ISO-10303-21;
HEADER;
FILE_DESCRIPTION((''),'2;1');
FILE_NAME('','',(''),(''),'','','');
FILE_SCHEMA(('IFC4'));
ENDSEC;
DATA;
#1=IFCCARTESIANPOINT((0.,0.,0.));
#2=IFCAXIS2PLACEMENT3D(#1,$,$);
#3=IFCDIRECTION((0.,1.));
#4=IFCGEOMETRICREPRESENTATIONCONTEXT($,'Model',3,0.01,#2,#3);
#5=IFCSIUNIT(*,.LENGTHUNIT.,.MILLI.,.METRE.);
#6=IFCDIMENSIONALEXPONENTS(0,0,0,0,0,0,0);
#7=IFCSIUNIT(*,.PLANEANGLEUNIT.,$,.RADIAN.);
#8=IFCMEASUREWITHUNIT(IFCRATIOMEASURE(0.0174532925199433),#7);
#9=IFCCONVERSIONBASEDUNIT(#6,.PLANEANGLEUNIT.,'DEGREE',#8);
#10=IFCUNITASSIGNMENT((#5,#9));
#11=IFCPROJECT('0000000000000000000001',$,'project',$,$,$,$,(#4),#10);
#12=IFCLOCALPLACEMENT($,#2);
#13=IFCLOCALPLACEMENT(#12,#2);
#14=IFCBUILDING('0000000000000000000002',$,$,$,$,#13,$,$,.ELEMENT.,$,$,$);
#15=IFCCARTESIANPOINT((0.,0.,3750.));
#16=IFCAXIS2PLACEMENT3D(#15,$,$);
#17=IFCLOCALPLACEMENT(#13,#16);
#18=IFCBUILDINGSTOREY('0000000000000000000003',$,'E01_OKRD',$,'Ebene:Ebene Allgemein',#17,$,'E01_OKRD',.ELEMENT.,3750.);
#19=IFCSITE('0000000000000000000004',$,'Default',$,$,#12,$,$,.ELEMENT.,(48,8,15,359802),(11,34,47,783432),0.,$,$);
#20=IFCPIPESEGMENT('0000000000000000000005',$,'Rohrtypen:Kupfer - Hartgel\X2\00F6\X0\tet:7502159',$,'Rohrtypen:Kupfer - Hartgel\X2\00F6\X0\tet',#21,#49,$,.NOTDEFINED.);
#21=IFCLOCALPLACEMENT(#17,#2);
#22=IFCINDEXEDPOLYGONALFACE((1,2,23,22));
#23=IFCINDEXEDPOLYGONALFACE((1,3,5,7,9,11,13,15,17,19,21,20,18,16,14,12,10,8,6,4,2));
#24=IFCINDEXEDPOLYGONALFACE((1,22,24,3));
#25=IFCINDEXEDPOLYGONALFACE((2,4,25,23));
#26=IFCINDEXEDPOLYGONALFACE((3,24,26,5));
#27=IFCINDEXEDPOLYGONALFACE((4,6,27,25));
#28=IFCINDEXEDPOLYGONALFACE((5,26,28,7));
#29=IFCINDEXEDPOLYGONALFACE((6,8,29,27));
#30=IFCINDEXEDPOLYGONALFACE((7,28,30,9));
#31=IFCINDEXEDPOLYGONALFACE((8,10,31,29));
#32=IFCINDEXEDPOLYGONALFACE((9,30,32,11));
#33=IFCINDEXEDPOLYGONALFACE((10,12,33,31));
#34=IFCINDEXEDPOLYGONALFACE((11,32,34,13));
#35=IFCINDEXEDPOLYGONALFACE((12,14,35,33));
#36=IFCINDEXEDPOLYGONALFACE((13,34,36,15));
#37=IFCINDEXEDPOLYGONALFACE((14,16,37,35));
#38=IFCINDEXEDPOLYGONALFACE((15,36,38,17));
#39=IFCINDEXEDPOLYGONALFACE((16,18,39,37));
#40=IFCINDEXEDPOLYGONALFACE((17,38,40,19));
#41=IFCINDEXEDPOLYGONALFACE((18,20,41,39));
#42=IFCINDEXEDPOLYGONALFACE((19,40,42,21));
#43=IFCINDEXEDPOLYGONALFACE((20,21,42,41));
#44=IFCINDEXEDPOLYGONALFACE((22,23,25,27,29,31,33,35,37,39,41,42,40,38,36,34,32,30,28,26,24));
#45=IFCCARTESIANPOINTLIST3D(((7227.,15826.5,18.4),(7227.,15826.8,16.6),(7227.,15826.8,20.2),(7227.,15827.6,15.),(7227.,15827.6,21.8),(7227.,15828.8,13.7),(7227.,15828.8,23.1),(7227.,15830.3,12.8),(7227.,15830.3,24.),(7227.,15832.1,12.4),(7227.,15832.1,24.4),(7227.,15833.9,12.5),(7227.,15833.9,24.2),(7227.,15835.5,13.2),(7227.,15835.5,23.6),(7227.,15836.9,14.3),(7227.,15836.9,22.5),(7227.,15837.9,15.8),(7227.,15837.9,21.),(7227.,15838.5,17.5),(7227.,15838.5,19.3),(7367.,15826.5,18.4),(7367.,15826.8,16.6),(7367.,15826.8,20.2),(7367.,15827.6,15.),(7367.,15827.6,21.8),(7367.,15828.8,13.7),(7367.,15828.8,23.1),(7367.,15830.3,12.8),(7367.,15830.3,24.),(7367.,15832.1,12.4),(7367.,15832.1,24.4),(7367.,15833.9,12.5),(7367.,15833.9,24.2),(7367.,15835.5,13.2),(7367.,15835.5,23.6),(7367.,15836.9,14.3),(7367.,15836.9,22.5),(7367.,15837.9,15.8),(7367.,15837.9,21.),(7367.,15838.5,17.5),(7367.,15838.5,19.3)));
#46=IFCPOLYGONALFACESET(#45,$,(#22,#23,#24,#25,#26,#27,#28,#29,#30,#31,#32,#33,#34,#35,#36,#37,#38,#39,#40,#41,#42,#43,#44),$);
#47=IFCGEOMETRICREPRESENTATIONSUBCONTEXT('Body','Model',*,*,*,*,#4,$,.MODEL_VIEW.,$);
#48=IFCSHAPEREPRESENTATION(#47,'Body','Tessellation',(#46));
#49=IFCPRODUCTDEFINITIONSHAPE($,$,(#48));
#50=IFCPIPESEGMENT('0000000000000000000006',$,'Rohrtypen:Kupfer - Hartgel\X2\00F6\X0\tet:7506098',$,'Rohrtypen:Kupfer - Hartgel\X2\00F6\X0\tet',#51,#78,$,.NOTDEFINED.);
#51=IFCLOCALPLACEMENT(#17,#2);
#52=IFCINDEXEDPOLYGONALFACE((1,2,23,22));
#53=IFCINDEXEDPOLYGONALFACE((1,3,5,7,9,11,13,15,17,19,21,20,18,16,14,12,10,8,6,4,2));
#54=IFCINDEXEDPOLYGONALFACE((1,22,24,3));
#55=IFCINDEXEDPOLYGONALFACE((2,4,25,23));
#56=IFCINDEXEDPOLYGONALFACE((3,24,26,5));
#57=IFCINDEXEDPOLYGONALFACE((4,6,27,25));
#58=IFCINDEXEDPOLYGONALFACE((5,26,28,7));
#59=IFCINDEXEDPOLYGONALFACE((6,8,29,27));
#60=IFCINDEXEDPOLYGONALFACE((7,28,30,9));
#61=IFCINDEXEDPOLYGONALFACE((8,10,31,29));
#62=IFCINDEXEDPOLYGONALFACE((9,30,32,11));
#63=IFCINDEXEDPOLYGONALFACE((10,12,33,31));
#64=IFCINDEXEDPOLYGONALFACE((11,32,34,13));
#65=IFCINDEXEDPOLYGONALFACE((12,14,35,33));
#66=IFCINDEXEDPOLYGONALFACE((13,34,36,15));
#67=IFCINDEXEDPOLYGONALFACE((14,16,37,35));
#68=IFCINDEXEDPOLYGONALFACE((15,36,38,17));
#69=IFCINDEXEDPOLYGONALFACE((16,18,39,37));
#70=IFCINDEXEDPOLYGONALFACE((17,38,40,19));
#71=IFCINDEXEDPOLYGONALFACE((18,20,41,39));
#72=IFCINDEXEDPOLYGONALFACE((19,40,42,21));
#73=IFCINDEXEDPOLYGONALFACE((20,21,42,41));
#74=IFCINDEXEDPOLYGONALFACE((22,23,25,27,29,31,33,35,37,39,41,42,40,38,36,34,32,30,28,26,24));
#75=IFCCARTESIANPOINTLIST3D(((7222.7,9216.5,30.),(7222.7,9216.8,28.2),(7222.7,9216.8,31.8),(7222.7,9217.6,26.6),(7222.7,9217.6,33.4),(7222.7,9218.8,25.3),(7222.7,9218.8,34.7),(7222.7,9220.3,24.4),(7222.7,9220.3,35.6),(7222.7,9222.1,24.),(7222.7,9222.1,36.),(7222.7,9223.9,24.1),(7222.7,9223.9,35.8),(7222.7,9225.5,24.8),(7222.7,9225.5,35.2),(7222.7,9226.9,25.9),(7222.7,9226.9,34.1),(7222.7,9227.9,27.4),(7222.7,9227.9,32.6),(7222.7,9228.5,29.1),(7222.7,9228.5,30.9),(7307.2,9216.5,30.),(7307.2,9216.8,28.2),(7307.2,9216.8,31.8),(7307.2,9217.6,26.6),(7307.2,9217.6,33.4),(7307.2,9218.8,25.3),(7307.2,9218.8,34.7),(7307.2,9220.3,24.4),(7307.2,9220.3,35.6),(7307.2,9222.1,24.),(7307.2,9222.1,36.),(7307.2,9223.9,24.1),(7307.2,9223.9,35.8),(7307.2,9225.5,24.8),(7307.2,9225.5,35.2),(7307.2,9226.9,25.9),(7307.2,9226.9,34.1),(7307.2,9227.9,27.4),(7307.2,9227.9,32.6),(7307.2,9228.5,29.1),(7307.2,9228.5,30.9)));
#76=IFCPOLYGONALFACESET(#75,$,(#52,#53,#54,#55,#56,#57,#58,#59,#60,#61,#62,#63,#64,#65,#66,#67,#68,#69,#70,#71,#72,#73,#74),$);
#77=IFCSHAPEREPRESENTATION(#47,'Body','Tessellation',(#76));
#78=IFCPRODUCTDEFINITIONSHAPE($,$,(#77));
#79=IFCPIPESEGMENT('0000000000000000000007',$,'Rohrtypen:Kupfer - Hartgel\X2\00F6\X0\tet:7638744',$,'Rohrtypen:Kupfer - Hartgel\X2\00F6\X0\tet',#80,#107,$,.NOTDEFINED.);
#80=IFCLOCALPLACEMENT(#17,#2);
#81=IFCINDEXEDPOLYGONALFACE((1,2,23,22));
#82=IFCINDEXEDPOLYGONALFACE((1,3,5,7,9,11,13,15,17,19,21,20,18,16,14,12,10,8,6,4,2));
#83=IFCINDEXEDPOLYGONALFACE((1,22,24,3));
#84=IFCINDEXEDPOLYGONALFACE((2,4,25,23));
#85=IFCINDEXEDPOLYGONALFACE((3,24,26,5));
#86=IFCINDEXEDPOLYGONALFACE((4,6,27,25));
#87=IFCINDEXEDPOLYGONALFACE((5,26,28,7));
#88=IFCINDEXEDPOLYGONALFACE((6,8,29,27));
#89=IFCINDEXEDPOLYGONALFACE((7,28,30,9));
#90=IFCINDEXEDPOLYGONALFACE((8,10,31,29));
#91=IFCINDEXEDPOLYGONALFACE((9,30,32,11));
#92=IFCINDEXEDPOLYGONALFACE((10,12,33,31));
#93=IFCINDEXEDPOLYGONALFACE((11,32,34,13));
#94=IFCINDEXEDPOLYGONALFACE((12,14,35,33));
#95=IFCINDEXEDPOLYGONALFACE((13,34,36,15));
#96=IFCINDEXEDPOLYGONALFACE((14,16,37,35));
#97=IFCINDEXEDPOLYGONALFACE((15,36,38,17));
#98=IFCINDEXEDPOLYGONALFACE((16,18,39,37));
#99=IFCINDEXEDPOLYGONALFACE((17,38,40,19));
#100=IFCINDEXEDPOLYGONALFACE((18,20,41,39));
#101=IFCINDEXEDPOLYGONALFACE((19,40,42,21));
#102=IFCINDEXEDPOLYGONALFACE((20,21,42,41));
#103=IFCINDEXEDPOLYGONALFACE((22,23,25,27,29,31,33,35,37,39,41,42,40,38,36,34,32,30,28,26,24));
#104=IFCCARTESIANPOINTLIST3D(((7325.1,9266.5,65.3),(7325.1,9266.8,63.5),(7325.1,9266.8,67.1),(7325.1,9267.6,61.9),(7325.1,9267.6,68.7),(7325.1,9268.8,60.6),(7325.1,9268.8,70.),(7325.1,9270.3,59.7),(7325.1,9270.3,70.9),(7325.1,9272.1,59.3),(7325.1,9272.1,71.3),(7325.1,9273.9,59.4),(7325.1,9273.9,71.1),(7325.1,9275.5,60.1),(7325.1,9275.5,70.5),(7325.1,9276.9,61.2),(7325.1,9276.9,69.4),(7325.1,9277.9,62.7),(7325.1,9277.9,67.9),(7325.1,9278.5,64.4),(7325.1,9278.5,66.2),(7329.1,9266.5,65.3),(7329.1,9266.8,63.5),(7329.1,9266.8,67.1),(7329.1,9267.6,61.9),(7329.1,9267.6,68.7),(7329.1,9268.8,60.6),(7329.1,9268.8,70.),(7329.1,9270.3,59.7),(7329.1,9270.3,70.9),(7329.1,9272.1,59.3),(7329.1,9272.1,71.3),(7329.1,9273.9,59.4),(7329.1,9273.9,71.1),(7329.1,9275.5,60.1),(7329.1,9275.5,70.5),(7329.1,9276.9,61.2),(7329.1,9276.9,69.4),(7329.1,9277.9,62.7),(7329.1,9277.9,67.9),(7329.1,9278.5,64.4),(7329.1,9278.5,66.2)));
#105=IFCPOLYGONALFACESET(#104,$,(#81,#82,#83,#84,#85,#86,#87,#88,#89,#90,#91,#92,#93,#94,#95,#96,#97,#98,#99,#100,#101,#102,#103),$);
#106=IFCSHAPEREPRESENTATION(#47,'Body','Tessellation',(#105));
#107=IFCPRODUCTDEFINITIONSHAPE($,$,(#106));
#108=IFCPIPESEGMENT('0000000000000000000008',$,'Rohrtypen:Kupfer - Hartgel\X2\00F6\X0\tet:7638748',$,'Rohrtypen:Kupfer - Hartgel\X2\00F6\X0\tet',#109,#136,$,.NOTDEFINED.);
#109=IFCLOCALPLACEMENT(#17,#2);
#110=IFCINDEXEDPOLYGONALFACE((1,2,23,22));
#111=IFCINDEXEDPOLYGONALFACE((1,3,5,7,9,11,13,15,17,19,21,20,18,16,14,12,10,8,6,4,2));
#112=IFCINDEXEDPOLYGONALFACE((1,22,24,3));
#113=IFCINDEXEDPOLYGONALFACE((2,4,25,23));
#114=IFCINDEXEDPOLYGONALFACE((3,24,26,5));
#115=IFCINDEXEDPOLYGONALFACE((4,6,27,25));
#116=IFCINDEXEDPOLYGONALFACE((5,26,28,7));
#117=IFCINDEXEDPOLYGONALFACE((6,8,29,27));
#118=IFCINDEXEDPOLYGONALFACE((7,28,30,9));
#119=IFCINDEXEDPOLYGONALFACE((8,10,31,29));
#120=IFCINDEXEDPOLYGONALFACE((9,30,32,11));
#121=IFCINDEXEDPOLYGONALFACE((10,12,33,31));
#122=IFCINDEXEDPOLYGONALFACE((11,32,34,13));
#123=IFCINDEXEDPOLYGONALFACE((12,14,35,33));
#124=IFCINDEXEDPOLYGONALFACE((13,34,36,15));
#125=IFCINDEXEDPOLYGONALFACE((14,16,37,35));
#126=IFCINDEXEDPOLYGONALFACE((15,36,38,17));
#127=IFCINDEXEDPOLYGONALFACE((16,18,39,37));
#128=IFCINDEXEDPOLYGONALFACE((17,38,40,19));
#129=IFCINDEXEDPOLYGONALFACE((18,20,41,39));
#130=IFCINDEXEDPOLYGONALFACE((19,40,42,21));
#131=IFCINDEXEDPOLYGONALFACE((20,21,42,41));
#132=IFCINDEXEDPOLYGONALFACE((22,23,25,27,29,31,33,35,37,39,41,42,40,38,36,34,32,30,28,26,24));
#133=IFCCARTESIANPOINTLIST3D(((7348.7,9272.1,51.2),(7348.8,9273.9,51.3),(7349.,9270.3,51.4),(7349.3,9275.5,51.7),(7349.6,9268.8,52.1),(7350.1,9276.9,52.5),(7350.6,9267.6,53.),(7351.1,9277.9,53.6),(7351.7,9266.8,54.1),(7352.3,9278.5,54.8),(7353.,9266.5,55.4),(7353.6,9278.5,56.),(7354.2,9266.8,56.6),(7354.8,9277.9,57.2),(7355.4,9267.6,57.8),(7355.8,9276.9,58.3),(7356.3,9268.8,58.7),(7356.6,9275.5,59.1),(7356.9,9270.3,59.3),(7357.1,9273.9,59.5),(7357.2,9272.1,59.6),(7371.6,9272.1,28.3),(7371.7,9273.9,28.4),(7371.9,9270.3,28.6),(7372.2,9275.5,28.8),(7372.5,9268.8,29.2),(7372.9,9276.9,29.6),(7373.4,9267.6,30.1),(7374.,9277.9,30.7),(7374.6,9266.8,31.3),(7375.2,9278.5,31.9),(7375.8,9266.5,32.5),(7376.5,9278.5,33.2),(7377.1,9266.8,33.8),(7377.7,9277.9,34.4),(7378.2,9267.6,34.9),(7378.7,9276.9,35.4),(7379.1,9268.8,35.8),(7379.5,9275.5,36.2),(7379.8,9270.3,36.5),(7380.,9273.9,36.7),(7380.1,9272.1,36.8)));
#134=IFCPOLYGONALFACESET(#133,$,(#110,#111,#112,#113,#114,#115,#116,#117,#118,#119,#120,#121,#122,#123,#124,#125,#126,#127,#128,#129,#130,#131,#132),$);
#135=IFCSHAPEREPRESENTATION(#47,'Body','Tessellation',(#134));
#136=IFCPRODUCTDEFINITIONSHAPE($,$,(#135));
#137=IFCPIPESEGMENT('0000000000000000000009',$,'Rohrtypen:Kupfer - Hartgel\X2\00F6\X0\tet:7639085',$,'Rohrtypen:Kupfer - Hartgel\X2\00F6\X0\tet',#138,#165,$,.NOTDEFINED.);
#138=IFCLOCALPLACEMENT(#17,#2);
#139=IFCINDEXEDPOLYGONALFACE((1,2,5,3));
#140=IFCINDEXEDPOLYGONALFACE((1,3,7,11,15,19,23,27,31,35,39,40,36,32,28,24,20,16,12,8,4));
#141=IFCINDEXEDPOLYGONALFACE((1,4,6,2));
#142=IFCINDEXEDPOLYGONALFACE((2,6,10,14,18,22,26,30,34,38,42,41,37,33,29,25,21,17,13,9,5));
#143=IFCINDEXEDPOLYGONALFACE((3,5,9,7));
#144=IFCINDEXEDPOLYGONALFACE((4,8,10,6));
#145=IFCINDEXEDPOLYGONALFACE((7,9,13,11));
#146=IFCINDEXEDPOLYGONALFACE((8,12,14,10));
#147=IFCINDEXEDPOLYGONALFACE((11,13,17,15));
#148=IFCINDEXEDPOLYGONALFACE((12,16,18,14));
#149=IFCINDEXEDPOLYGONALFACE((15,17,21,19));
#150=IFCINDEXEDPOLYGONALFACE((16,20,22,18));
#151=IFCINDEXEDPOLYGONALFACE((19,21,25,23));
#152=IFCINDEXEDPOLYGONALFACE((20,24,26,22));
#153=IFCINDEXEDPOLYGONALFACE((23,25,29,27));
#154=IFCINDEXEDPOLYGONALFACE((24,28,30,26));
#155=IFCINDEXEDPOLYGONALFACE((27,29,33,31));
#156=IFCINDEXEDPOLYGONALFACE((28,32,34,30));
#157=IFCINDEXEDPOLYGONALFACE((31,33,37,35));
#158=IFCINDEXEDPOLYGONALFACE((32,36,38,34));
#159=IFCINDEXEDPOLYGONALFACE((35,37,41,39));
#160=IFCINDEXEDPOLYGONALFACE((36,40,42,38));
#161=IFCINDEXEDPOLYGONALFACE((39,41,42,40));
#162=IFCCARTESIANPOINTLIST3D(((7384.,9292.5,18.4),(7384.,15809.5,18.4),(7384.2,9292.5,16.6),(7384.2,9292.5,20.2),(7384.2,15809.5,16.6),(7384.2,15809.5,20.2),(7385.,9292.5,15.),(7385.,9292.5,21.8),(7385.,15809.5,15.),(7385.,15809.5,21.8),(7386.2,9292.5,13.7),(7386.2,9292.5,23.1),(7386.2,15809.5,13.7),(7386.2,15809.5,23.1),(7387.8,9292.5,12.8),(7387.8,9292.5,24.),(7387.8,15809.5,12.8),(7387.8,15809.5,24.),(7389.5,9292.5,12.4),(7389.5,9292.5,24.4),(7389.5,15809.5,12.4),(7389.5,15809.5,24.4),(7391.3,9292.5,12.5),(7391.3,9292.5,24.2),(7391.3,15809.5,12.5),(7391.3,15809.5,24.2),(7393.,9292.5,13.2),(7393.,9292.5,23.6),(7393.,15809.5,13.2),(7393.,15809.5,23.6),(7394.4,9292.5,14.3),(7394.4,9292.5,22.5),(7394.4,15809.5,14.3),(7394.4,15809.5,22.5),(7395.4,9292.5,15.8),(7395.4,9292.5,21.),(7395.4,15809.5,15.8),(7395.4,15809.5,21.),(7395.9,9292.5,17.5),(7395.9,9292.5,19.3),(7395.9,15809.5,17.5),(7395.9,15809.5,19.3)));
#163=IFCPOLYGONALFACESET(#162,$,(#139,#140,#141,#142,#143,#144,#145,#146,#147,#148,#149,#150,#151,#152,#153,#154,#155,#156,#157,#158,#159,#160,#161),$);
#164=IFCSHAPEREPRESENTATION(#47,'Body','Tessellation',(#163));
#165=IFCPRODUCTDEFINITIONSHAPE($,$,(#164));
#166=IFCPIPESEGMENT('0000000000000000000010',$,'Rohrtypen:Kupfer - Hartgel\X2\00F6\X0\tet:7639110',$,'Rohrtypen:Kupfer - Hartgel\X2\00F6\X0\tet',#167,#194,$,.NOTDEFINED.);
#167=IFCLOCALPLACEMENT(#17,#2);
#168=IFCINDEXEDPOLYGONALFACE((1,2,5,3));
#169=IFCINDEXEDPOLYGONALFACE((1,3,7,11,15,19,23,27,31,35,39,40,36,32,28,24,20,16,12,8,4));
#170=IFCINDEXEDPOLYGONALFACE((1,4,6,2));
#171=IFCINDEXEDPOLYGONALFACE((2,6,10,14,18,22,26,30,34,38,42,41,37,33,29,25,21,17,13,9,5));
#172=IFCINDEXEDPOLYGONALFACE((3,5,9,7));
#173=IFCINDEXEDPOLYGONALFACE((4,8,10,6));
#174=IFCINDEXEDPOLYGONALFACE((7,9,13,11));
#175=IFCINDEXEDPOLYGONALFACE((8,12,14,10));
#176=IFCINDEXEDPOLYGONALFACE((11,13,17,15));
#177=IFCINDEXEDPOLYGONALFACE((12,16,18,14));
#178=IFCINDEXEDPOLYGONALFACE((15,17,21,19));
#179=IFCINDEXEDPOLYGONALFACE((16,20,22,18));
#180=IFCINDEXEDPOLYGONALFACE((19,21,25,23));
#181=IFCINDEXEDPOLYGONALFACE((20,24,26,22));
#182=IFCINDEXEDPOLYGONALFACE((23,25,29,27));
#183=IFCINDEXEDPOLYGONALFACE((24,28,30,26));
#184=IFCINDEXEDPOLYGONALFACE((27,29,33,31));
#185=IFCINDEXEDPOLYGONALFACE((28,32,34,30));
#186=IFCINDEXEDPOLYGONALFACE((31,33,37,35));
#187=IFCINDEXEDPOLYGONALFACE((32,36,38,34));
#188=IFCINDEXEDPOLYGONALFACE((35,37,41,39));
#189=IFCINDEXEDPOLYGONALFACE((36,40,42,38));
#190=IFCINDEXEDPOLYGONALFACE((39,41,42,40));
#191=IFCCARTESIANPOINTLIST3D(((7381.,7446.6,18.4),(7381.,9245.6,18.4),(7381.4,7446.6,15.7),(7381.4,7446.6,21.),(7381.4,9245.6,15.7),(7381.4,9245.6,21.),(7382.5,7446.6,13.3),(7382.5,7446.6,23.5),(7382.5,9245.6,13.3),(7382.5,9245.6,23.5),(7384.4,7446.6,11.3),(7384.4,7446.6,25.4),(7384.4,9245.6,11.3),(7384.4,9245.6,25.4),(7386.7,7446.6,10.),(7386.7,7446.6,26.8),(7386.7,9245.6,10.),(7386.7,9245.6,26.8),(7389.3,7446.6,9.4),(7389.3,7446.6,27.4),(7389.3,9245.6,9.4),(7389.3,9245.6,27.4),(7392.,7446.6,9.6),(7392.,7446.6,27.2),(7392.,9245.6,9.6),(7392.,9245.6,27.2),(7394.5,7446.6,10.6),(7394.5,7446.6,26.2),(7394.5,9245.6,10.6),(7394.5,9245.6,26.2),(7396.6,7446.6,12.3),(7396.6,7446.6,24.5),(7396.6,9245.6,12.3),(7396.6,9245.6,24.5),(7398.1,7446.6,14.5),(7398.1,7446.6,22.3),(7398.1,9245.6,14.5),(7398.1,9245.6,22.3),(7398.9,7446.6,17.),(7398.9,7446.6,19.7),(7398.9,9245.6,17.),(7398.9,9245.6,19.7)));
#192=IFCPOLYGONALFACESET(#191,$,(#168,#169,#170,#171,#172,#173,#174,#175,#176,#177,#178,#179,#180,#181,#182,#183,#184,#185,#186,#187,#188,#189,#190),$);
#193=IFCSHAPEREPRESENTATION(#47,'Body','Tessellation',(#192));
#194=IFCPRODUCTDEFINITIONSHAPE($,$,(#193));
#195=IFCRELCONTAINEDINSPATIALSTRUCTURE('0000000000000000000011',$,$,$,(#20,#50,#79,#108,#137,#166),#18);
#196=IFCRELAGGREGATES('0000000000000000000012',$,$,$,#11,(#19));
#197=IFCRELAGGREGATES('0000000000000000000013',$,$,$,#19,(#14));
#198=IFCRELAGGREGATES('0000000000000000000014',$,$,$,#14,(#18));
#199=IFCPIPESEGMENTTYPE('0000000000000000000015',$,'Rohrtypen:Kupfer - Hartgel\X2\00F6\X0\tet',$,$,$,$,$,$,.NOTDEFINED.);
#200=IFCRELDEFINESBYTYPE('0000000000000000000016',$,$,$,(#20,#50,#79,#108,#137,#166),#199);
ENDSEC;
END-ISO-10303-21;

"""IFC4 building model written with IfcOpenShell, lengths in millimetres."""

from ifc_helpers import new_model, entity, si_unit, converted_unit, direction, frame, frame_2d, origin, origin_2d_with_axis, place, context, subcontext, project, spatial, circle, extrude, type_object, element, save


model = new_model("IFC4")

# Units and contexts
model_context = context("Model", 3, precision=0.01, world=origin(), true_north=direction((0.0, 1.0)))
body_context = subcontext(model_context, "Body", "Model", "MODEL_VIEW")
ifc_project = project(units=[si_unit("LENGTHUNIT", "METRE", prefix="MILLI"), converted_unit("PLANEANGLEUNIT", "DEGREE", entity("IfcRatioMeasure", 0.0174532925199433), si_unit("PLANEANGLEUNIT", "RADIAN"), dimensions=[0, 0, 0, 0, 0, 0, 0])], contexts=[model_context])

# Site, building, storey
site_placement = place(None, origin())
site = spatial("IfcSite", under=ifc_project, at=site_placement, Name="Default", CompositionType="ELEMENT", RefLatitude=(48, 8, 15, 359802), RefLongitude=(11, 34, 47, 783432), RefElevation=0.0)
building_placement = place(site_placement, origin())
building = spatial("IfcBuilding", under=site, at=building_placement, CompositionType="ELEMENT")
storey_placement = place(building_placement, frame((0.0, 0.0, 3750.0)))
storey = spatial("IfcBuildingStorey", under=building, at=storey_placement, Name="E01_OKRD", ObjectType="Ebene:Ebene Allgemein", LongName="E01_OKRD", CompositionType="ELEMENT", Elevation=3750.0)

# Pipe segments
pipe_segment_type = type_object("IfcPipeSegmentType", Name="Rohrtypen:Kupfer - Hartgelötet", PredefinedType="NOTDEFINED")
pipe_segment_1_placement = place(storey_placement, frame((7227.0, 15824.9, 10.8)))
element("IfcPipeSegment", 1, at=pipe_segment_1_placement, inside=storey, type_object=pipe_segment_type, Name="Rohrtypen:Kupfer - Hartgelötet:7502159", ObjectType="Rohrtypen:Kupfer - Hartgelötet", PredefinedType="NOTDEFINED", context=body_context, shape_type="SweptSolid", body=[
    extrude(circle(Radius=6.0, at=origin_2d_with_axis()), frame((0.0, 7.6, 7.6), z_axis=(1.0, 0.0, 0.0), x_axis=(0.0, -1.0, 0.0)), (0.0, 0.0, 1.0), 140.0),
])
pipe_segment_2_placement = place(storey_placement, frame((7222.7, 9214.9, 22.4)))
element("IfcPipeSegment", 2, at=pipe_segment_2_placement, inside=storey, type_object=pipe_segment_type, Name="Rohrtypen:Kupfer - Hartgelötet:7506098", ObjectType="Rohrtypen:Kupfer - Hartgelötet", PredefinedType="NOTDEFINED", context=body_context, shape_type="SweptSolid", body=[
    extrude(circle(Radius=6.0, at=origin_2d_with_axis()), frame((0.0, 7.6, 7.6), z_axis=(1.0, 0.0, 0.00013), x_axis=(0.0, -1.0, 0.0)), (0.0, 0.0, 1.0), 84.5),
])
pipe_segment_3_placement = place(storey_placement, frame((7325.1, 9264.9, 57.7)))
element("IfcPipeSegment", 3, at=pipe_segment_3_placement, inside=storey, type_object=pipe_segment_type, Name="Rohrtypen:Kupfer - Hartgelötet:7638744", ObjectType="Rohrtypen:Kupfer - Hartgelötet", PredefinedType="NOTDEFINED", context=body_context, shape_type="SweptSolid", body=[
    extrude(circle(Radius=6.0, at=frame_2d((0.0, 0.0), x_axis=(1.0, 0.0))), frame((0.0, 7.6, 7.6), z_axis=(1.0, 0.000746, 0.0), x_axis=(0.000746, -1.0, 0.0)), (0.0, 0.0, 1.0), 3.9),
])
pipe_segment_4_placement = place(storey_placement, frame((7347.1, 9264.9, 26.7)))
element("IfcPipeSegment", 4, at=pipe_segment_4_placement, inside=storey, type_object=pipe_segment_type, Name="Rohrtypen:Kupfer - Hartgelötet:7638748", ObjectType="Rohrtypen:Kupfer - Hartgelötet", PredefinedType="NOTDEFINED", context=body_context, shape_type="SweptSolid", body=[
    extrude(circle(Radius=6.0, at=origin_2d_with_axis()), frame((28.7, 7.6, 5.8), z_axis=(-0.707107, 0.0, 0.707107), x_axis=(0.0, -1.0, 0.0)), (0.0, 0.0, 1.0), 32.3),
])
pipe_segment_5_placement = place(storey_placement, frame((7382.4, 9292.5, 10.8)))
element("IfcPipeSegment", 5, at=pipe_segment_5_placement, inside=storey, type_object=pipe_segment_type, Name="Rohrtypen:Kupfer - Hartgelötet:7639085", ObjectType="Rohrtypen:Kupfer - Hartgelötet", PredefinedType="NOTDEFINED", context=body_context, shape_type="SweptSolid", body=[
    extrude(circle(Radius=6.0, at=frame_2d((0.0, 0.0), x_axis=(1.0, 0.0))), frame((7.6, 0.0, 7.6), z_axis=(0.0, 1.0, 0.0), x_axis=(-1.0, 0.0, 0.0)), (0.0, 0.0, 1.0), 6517.0),
])
pipe_segment_6_placement = place(storey_placement, frame((7379.4, 7446.6, 7.8)))
element("IfcPipeSegment", 6, at=pipe_segment_6_placement, inside=storey, type_object=pipe_segment_type, Name="Rohrtypen:Kupfer - Hartgelötet:7639110", ObjectType="Rohrtypen:Kupfer - Hartgelötet", PredefinedType="NOTDEFINED", context=body_context, shape_type="SweptSolid", body=[
    extrude(circle(Radius=9.0, at=origin_2d_with_axis()), frame((10.6, 0.0, 10.6), z_axis=(0.0, 1.0, 0.0), x_axis=(-1.0, 0.0, 0.0)), (0.0, 0.0, 1.0), 1799.1),
])

save(model, "model.ifc")
